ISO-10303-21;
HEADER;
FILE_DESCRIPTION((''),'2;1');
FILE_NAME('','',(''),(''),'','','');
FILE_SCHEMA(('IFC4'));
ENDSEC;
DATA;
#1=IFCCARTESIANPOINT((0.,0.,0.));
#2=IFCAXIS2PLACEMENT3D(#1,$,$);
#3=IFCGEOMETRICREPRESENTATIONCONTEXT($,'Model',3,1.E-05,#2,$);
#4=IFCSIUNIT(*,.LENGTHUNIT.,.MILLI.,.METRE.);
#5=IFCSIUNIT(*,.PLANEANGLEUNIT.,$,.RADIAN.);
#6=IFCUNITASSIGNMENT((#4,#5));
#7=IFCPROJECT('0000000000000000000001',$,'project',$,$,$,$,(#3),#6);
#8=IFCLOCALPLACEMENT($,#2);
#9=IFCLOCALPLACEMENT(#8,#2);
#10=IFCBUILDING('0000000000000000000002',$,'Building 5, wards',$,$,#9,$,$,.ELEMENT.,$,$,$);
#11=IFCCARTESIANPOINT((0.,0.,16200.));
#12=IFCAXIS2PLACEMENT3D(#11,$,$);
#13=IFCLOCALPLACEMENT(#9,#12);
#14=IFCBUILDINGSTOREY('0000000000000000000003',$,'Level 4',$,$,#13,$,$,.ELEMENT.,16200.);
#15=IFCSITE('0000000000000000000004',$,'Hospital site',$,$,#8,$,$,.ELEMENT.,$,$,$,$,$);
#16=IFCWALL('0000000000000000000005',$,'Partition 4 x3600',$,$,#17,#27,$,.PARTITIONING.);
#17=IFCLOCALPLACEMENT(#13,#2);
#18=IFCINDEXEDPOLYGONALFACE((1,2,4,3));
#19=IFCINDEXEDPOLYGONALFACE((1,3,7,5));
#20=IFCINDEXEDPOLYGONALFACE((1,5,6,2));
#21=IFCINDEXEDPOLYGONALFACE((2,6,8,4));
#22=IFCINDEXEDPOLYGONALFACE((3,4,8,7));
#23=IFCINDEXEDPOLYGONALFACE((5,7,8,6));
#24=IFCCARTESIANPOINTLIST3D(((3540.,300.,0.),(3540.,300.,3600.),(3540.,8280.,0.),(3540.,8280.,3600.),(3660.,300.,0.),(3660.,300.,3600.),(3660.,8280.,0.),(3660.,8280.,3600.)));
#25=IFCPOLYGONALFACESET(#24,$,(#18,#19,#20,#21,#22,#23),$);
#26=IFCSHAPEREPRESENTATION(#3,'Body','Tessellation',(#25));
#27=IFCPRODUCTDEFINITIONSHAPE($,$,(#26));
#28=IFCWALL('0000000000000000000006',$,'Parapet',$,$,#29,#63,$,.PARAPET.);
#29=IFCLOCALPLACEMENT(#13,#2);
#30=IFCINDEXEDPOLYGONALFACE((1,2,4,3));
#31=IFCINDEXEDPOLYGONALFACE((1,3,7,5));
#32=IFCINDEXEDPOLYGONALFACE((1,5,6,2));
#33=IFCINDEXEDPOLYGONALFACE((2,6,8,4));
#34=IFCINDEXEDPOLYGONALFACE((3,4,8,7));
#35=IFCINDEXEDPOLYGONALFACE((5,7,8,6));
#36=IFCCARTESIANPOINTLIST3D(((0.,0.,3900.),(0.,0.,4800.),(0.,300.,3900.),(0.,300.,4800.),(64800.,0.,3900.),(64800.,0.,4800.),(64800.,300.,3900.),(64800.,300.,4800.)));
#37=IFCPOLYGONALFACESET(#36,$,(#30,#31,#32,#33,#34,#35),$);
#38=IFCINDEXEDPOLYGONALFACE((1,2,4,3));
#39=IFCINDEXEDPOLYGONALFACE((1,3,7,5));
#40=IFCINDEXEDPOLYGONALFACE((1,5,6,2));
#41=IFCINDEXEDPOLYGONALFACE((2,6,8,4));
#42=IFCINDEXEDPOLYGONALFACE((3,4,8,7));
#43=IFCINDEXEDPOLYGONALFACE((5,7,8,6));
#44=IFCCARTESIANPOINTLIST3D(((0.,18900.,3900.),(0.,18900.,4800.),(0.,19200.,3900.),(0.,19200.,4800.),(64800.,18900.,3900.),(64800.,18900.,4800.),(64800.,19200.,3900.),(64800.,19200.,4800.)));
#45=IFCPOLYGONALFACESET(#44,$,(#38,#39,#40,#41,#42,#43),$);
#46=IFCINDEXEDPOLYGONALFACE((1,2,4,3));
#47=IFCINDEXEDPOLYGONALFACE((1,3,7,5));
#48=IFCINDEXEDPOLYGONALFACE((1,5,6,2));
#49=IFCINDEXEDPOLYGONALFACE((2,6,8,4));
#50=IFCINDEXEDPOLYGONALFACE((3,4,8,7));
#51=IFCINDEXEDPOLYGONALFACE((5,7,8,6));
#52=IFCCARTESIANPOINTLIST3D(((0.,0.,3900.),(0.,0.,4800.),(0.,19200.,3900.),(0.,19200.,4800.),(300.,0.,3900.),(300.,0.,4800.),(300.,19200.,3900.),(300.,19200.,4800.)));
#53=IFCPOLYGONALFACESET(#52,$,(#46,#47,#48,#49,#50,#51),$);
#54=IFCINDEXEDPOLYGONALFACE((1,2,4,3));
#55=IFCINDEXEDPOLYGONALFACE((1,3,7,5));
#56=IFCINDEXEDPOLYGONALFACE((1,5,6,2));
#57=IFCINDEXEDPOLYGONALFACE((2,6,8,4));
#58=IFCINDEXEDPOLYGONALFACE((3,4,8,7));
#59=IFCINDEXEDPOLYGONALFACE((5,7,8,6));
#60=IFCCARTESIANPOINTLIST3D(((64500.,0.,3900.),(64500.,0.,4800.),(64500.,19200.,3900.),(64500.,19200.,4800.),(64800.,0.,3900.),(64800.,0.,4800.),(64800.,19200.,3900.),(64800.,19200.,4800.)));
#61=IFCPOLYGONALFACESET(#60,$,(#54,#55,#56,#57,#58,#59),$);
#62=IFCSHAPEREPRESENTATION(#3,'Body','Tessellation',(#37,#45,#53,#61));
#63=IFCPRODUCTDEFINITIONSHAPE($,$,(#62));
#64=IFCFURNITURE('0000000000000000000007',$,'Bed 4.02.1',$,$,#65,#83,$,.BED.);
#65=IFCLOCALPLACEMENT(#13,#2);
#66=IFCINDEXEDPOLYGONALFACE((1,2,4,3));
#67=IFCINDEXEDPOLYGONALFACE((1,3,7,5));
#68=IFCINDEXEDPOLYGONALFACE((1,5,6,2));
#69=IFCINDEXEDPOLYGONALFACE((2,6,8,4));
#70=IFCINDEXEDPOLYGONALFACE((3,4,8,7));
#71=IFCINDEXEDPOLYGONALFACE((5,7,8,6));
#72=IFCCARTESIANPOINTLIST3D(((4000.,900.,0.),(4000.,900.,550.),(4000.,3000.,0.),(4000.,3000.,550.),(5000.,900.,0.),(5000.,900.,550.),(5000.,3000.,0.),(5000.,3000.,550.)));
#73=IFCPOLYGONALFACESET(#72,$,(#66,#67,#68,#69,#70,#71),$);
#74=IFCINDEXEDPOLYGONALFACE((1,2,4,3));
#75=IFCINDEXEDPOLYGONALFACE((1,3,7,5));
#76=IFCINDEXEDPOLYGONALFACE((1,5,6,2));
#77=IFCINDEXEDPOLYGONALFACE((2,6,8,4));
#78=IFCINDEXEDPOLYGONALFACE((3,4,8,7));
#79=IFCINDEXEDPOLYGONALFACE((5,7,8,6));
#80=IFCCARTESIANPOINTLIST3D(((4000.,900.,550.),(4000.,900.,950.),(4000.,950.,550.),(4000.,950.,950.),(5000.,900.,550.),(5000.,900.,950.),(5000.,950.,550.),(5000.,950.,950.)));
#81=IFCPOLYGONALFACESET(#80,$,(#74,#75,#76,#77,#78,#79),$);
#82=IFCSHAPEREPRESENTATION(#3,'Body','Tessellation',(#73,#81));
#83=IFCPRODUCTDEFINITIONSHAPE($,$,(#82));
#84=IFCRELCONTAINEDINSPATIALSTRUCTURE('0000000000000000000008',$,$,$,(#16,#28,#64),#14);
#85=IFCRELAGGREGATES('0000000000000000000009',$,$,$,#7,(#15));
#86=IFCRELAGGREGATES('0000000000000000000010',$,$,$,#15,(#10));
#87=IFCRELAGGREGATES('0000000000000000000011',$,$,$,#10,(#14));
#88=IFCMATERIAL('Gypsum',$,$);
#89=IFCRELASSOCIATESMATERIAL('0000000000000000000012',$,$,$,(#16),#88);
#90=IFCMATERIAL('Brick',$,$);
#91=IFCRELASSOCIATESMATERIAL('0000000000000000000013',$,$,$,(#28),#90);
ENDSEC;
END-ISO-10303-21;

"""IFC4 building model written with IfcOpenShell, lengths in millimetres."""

from ifc_helpers import new_model, si_unit, frame, frame_2d, origin, place, context, project, spatial, rectangle, extrude, material, element, save


model = new_model("IFC4")

# Units and contexts
model_context = context("Model", 3, precision=1e-05, world=origin())
ifc_project = project(units=[si_unit("LENGTHUNIT", "METRE", prefix="MILLI"), si_unit("PLANEANGLEUNIT", "RADIAN")], contexts=[model_context])

# Site, building, storey
site_placement = place(None, origin())
site = spatial("IfcSite", under=ifc_project, at=site_placement, Name="Hospital site", CompositionType="ELEMENT")
building_placement = place(site_placement, origin())
building = spatial("IfcBuilding", under=site, at=building_placement, Name="Building 5, wards", CompositionType="ELEMENT")
storey_placement = place(building_placement, frame((0.0, 0.0, 16200.0)))
storey = spatial("IfcBuildingStorey", under=building, at=storey_placement, Name="Level 4", CompositionType="ELEMENT", Elevation=16200.0)

# Walls
ifc_material_1 = material(Name="Gypsum")
wall_1_placement = place(storey_placement, frame((3660.0, 300.0, 0.0), x_axis=(0.0, 1.0, 0.0)))
element("IfcWall", 1, at=wall_1_placement, inside=storey, material=ifc_material_1, Name="Partition 4 x3600", PredefinedType="PARTITIONING", context=model_context, shape_type="SweptSolid", body=[
    extrude(rectangle(XDim=7980.0, YDim=120.0, at=frame_2d((3990.0, 60.0))), origin(), (0.0, 0.0, 1.0), 3600.0),
])
ifc_material_2 = material(Name="Brick")
wall_2_placement = place(storey_placement, frame((0.0, 0.0, 3900.0)))
element("IfcWall", 2, at=wall_2_placement, inside=storey, material=ifc_material_2, Name="Parapet", PredefinedType="PARAPET", context=model_context, shape_type="SweptSolid", body=[
    extrude(rectangle(XDim=64800.0, YDim=300.0, at=frame_2d((32400.0, 150.0))), origin(), (0.0, 0.0, 1.0), 900.0),
    extrude(rectangle(XDim=64800.0, YDim=300.0, at=frame_2d((32400.0, 19050.0))), origin(), (0.0, 0.0, 1.0), 900.0),
    extrude(rectangle(XDim=300.0, YDim=19200.0, at=frame_2d((150.0, 9600.0))), origin(), (0.0, 0.0, 1.0), 900.0),
    extrude(rectangle(XDim=300.0, YDim=19200.0, at=frame_2d((64650.0, 9600.0))), origin(), (0.0, 0.0, 1.0), 900.0),
])

# Furniture
furniture_placement = place(storey_placement, frame((4000.0, 900.0, 0.0)))
element("IfcFurniture", 3, at=furniture_placement, inside=storey, Name="Bed 4.02.1", PredefinedType="BED", context=model_context, shape_type="SweptSolid", body=[
    extrude(rectangle(XDim=1000.0, YDim=2100.0, at=frame_2d((500.0, 1050.0))), origin(), (0.0, 0.0, 1.0), 550.0),
    extrude(rectangle(XDim=1000.0, YDim=50.0, at=frame_2d((500.0, 25.0))), frame((0.0, 0.0, 550.0)), (0.0, 0.0, 1.0), 400.0),
])

save(model, "model.ifc")
